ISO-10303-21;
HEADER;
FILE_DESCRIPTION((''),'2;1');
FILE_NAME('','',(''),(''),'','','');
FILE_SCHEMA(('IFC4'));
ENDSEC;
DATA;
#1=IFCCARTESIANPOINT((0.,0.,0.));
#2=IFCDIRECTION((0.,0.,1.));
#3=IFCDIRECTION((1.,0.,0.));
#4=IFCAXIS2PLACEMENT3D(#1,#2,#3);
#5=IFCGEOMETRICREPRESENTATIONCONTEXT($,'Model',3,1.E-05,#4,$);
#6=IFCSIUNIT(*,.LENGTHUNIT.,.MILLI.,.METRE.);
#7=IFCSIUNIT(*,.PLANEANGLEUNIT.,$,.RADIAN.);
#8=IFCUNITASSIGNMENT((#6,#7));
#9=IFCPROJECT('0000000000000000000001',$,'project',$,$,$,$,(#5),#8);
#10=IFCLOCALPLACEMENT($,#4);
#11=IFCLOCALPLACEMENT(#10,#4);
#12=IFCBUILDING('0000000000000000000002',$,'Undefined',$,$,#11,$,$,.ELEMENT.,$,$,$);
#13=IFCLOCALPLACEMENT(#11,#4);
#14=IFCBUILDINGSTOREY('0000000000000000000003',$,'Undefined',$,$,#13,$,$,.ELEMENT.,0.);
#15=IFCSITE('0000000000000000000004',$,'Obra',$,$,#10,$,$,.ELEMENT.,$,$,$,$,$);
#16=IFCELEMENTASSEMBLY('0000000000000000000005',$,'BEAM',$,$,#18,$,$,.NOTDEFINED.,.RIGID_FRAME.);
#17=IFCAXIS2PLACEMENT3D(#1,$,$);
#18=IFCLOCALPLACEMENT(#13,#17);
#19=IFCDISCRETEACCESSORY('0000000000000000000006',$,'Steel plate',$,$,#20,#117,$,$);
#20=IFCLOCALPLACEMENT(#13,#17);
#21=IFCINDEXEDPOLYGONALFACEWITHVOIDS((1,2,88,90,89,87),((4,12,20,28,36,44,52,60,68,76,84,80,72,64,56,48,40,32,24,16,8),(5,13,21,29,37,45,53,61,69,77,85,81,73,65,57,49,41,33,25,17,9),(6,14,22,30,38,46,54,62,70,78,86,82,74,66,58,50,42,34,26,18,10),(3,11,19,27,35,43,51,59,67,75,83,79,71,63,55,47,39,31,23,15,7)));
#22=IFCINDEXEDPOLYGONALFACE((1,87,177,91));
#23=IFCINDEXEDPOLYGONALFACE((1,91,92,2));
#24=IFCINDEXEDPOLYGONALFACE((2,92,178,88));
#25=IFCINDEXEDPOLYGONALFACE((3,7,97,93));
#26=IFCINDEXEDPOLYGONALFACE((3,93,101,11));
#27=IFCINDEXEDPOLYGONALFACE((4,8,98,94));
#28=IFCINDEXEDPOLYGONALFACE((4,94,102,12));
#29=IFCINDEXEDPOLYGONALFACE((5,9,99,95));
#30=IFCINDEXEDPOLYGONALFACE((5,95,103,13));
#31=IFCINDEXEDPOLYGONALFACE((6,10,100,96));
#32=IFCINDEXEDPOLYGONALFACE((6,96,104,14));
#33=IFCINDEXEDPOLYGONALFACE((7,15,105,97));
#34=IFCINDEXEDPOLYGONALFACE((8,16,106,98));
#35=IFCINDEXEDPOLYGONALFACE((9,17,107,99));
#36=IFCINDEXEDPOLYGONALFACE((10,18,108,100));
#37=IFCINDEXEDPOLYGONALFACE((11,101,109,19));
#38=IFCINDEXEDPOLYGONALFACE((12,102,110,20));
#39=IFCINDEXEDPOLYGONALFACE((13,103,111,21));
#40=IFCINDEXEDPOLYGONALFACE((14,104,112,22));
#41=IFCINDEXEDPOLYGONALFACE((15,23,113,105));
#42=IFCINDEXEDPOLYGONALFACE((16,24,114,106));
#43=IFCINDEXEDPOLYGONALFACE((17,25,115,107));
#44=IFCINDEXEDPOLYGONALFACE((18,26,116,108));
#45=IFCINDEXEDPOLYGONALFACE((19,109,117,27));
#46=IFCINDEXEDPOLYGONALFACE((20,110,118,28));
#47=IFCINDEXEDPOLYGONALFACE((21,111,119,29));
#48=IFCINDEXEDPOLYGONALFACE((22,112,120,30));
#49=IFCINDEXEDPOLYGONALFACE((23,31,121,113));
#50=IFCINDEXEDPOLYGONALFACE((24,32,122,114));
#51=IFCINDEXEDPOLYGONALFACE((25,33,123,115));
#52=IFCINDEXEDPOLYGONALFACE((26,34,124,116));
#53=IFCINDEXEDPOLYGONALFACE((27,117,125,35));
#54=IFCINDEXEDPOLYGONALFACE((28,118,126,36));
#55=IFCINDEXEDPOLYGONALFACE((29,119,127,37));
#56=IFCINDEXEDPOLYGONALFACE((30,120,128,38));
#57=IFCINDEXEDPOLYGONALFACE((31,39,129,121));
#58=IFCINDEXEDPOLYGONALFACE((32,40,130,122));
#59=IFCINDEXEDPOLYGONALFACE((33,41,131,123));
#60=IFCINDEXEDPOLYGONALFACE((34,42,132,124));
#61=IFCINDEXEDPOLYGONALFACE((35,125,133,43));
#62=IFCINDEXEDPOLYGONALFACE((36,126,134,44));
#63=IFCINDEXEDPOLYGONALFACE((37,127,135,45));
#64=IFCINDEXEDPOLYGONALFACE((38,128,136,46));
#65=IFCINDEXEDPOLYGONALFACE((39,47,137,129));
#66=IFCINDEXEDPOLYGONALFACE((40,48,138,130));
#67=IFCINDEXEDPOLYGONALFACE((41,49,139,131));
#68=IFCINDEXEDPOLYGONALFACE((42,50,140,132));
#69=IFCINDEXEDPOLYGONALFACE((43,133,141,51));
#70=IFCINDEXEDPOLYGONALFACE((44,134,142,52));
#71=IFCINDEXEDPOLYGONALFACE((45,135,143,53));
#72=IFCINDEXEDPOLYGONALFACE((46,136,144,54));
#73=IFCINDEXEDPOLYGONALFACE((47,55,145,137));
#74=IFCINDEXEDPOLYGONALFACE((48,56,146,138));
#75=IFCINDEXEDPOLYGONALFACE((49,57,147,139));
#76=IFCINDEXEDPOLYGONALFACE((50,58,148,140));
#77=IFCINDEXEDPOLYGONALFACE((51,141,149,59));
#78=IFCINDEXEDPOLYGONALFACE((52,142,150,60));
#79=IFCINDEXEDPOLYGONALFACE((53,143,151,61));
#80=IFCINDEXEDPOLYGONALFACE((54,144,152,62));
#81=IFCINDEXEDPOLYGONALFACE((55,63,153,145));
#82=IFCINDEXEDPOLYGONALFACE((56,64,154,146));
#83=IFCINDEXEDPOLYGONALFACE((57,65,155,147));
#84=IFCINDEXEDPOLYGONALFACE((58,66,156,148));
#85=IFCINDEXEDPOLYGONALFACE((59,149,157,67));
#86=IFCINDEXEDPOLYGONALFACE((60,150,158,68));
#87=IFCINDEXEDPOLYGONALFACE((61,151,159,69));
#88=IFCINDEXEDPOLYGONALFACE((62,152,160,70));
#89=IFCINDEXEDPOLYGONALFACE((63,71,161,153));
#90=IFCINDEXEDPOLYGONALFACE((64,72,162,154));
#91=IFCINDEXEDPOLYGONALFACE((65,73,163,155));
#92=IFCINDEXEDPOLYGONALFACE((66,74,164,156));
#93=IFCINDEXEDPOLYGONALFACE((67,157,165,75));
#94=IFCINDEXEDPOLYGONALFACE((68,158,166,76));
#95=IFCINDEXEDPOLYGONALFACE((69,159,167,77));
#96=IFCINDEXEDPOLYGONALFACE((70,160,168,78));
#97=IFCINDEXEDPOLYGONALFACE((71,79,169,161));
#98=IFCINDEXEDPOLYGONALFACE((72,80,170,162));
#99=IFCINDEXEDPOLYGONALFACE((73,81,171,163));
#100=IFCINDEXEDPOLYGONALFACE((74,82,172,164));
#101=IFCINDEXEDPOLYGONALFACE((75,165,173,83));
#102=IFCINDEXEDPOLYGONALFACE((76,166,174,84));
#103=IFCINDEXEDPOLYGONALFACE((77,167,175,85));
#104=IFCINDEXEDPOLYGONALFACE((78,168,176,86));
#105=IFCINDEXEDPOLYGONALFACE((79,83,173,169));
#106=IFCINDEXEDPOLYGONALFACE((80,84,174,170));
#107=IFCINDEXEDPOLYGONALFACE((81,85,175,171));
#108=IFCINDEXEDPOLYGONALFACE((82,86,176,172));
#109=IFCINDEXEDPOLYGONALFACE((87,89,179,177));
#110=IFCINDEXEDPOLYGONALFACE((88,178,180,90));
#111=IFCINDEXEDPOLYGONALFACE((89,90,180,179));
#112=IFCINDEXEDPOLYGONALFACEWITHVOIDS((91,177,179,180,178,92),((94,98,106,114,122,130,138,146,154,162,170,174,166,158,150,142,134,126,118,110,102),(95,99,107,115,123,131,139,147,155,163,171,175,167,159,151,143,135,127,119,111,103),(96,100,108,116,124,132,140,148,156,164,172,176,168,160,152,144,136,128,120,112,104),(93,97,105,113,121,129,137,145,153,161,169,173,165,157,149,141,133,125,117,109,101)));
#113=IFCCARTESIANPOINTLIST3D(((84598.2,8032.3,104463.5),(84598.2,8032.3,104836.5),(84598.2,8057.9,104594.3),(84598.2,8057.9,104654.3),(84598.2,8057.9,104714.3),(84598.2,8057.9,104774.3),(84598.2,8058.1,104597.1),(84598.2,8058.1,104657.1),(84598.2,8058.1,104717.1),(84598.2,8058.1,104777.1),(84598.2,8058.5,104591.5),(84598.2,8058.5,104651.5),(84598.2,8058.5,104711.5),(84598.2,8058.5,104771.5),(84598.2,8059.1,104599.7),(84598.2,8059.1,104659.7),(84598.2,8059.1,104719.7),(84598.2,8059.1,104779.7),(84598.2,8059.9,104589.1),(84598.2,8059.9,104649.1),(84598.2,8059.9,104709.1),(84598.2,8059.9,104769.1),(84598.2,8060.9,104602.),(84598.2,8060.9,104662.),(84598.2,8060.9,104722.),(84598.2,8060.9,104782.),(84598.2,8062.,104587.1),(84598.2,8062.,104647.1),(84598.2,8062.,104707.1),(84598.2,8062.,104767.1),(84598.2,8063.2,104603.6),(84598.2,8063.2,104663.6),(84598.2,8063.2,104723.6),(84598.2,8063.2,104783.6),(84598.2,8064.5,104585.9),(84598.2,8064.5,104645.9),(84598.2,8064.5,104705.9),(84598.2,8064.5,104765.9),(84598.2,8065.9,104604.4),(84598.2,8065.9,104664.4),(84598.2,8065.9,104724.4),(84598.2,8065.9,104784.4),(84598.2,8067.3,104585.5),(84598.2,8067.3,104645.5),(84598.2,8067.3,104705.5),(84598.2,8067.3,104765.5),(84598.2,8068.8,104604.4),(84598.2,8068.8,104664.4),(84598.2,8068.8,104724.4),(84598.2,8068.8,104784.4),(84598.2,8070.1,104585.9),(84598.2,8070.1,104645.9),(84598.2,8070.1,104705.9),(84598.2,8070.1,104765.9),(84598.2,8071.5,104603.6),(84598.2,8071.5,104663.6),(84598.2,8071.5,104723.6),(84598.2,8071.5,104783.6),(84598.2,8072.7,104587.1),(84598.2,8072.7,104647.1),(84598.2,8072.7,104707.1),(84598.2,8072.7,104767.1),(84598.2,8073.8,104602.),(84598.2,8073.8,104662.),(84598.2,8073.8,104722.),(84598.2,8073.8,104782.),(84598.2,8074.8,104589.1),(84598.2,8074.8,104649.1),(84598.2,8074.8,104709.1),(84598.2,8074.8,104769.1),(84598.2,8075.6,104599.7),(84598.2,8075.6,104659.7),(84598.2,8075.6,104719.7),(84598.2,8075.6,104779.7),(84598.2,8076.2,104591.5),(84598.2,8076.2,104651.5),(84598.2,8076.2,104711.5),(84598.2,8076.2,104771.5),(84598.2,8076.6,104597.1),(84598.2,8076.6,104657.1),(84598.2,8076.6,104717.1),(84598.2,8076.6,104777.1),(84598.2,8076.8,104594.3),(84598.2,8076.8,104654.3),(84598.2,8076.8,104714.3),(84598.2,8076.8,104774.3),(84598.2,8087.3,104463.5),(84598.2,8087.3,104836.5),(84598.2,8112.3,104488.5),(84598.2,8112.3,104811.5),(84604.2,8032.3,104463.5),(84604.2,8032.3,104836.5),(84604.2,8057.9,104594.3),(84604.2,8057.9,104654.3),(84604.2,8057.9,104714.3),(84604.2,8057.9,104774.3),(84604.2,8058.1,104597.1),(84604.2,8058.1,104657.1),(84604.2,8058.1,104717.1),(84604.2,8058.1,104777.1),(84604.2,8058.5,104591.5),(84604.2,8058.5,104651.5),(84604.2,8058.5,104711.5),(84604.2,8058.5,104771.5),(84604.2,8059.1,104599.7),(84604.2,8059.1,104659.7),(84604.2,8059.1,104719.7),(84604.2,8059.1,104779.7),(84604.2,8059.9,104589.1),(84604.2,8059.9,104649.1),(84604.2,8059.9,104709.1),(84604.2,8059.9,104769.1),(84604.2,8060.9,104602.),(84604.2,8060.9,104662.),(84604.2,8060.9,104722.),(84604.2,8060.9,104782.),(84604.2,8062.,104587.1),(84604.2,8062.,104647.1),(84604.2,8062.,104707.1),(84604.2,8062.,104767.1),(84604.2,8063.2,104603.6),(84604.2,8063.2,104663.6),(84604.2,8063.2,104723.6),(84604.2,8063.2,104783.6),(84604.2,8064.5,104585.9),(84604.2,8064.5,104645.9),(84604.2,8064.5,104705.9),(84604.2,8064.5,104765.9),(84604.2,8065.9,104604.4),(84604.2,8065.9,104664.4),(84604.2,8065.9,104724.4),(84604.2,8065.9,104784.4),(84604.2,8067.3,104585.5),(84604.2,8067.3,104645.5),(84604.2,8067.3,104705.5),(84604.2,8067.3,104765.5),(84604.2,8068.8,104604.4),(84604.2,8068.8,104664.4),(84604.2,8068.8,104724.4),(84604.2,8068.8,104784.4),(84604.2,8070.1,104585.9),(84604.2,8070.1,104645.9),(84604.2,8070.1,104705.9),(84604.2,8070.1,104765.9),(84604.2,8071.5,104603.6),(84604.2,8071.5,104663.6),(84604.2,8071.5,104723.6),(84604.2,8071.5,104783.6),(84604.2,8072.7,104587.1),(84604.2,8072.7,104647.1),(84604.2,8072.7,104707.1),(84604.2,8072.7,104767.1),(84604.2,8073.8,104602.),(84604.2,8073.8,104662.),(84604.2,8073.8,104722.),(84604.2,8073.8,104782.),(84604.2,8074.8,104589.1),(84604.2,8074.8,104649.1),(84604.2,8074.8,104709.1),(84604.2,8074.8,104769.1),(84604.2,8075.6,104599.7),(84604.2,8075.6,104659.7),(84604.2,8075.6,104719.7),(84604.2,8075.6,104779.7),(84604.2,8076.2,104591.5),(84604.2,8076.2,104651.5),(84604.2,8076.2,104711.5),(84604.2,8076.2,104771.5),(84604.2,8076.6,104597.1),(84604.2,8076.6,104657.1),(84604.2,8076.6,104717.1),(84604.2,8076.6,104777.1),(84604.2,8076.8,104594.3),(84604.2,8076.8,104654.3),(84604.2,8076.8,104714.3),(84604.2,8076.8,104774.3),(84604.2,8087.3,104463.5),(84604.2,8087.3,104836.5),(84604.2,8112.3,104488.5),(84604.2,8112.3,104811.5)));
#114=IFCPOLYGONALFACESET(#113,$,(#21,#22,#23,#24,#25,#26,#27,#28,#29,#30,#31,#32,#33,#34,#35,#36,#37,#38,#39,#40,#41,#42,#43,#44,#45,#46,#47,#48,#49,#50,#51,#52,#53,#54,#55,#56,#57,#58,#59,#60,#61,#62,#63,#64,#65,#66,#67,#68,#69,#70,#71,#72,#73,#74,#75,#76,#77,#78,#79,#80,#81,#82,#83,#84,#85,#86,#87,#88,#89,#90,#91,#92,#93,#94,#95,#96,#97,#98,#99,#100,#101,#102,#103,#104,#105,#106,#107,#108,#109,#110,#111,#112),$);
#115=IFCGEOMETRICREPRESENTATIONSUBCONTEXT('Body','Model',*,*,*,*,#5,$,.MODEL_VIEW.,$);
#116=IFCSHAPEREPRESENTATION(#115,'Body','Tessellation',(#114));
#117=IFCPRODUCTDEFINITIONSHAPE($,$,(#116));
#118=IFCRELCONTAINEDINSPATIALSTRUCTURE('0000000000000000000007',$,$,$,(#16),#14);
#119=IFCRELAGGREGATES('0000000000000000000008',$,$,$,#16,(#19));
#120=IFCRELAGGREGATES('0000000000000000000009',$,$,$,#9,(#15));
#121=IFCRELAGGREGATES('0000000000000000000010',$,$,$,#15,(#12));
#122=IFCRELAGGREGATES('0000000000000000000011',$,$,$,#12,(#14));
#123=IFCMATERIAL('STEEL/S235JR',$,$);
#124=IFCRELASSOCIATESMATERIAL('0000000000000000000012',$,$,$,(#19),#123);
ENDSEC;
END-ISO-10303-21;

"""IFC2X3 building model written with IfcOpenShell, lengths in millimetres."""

from ifc_helpers import new_model, si_unit, frame, origin_with_axes, origin_2d_with_axis, place, context, subcontext, project, spatial, polyline, circle, outline, extrude, source, transform, mapped, material, element, aggregate, save


model = new_model("IFC2X3")

# Units and contexts
model_context = context("Model", 3, precision=1e-05, world=origin_with_axes())
body_context = subcontext(model_context, "Body", "Model", "MODEL_VIEW")
ifc_project = project(units=[si_unit("LENGTHUNIT", "METRE", prefix="MILLI"), si_unit("PLANEANGLEUNIT", "RADIAN")], contexts=[model_context])

# Site, building, storey
site_placement = place(None, origin_with_axes())
site = spatial("IfcSite", under=ifc_project, at=site_placement, Name="Obra", CompositionType="ELEMENT")
building_placement = place(site_placement, origin_with_axes())
building = spatial("IfcBuilding", under=site, at=building_placement, Name="Undefined", CompositionType="ELEMENT")
storey_placement = place(building_placement, origin_with_axes())
storey = spatial("IfcBuildingStorey", under=building, at=storey_placement, Name="Undefined", CompositionType="ELEMENT", Elevation=0.0)

# Shared definitions
ifc_material = material(Name="STEEL/S235JR")

# Element assembly
assembly_1_placement = place(storey_placement, origin_with_axes())
assembly_1 = element("IfcElementAssembly", 1, at=assembly_1_placement, inside=storey, Name="BEAM", AssemblyPlace="NOTDEFINED", PredefinedType="RIGID_FRAME")

# Discrete accessory, opening
shared_shape_1 = source(origin_with_axes(), body_context, "Body", "SweptSolid", [
    extrude(circle(Radius=9.5, at=origin_2d_with_axis()), frame((0.0, -9.9, 0.0), z_axis=(0.0, 1.0, 0.0), x_axis=(1.0, 0.0, 0.0)), (0.0, 0.0, 1.0), 6.2),
])
discrete_accessory_1_placement = place(assembly_1_placement, frame((84601.2, 8032.3, 104463.5), z_axis=(1.0, 0.0, 0.0), x_axis=(0.0, 1.0, 0.0)))
discrete_accessory_1 = element("IfcDiscreteAccessory", 2, at=discrete_accessory_1_placement, material=ifc_material, Name="Steel plate", context=body_context, shape_type="SweptSolid", body=[
    extrude(outline(polyline([(0.0, 0.0), (55.0, 0.0), (80.0, 25.0), (80.0, 348.0), (55.0, 373.0), (0.0, 373.0), (0.0, 0.0)])), frame((0.0, 0.0, -3.0), z_axis=(0.0, 0.0, 1.0), x_axis=(1.0, 0.0, 0.0)), (0.0, 0.0, 1.0), 6.0),
])
opening_1_placement = place(assembly_1_placement, frame((84607.9, 8102.3, 104850.0), z_axis=(0.0, -1.0, 0.0), x_axis=(0.0, 0.0, -1.0)))
element("IfcOpeningElement", 3, at=opening_1_placement, cuts=discrete_accessory_1, ObjectType="Opening", context=body_context, shape_type="MappedRepresentation", body=[
    mapped(shared_shape_1, transform((75.0, 0.0, 35.0))),
    mapped(shared_shape_1, transform((135.0, 0.0, 35.0))),
    mapped(shared_shape_1, transform((195.0, 0.0, 35.0))),
    mapped(shared_shape_1, transform((255.0, 0.0, 35.0))),
])
aggregate(assembly_1, [discrete_accessory_1])

save(model, "model.ifc")
